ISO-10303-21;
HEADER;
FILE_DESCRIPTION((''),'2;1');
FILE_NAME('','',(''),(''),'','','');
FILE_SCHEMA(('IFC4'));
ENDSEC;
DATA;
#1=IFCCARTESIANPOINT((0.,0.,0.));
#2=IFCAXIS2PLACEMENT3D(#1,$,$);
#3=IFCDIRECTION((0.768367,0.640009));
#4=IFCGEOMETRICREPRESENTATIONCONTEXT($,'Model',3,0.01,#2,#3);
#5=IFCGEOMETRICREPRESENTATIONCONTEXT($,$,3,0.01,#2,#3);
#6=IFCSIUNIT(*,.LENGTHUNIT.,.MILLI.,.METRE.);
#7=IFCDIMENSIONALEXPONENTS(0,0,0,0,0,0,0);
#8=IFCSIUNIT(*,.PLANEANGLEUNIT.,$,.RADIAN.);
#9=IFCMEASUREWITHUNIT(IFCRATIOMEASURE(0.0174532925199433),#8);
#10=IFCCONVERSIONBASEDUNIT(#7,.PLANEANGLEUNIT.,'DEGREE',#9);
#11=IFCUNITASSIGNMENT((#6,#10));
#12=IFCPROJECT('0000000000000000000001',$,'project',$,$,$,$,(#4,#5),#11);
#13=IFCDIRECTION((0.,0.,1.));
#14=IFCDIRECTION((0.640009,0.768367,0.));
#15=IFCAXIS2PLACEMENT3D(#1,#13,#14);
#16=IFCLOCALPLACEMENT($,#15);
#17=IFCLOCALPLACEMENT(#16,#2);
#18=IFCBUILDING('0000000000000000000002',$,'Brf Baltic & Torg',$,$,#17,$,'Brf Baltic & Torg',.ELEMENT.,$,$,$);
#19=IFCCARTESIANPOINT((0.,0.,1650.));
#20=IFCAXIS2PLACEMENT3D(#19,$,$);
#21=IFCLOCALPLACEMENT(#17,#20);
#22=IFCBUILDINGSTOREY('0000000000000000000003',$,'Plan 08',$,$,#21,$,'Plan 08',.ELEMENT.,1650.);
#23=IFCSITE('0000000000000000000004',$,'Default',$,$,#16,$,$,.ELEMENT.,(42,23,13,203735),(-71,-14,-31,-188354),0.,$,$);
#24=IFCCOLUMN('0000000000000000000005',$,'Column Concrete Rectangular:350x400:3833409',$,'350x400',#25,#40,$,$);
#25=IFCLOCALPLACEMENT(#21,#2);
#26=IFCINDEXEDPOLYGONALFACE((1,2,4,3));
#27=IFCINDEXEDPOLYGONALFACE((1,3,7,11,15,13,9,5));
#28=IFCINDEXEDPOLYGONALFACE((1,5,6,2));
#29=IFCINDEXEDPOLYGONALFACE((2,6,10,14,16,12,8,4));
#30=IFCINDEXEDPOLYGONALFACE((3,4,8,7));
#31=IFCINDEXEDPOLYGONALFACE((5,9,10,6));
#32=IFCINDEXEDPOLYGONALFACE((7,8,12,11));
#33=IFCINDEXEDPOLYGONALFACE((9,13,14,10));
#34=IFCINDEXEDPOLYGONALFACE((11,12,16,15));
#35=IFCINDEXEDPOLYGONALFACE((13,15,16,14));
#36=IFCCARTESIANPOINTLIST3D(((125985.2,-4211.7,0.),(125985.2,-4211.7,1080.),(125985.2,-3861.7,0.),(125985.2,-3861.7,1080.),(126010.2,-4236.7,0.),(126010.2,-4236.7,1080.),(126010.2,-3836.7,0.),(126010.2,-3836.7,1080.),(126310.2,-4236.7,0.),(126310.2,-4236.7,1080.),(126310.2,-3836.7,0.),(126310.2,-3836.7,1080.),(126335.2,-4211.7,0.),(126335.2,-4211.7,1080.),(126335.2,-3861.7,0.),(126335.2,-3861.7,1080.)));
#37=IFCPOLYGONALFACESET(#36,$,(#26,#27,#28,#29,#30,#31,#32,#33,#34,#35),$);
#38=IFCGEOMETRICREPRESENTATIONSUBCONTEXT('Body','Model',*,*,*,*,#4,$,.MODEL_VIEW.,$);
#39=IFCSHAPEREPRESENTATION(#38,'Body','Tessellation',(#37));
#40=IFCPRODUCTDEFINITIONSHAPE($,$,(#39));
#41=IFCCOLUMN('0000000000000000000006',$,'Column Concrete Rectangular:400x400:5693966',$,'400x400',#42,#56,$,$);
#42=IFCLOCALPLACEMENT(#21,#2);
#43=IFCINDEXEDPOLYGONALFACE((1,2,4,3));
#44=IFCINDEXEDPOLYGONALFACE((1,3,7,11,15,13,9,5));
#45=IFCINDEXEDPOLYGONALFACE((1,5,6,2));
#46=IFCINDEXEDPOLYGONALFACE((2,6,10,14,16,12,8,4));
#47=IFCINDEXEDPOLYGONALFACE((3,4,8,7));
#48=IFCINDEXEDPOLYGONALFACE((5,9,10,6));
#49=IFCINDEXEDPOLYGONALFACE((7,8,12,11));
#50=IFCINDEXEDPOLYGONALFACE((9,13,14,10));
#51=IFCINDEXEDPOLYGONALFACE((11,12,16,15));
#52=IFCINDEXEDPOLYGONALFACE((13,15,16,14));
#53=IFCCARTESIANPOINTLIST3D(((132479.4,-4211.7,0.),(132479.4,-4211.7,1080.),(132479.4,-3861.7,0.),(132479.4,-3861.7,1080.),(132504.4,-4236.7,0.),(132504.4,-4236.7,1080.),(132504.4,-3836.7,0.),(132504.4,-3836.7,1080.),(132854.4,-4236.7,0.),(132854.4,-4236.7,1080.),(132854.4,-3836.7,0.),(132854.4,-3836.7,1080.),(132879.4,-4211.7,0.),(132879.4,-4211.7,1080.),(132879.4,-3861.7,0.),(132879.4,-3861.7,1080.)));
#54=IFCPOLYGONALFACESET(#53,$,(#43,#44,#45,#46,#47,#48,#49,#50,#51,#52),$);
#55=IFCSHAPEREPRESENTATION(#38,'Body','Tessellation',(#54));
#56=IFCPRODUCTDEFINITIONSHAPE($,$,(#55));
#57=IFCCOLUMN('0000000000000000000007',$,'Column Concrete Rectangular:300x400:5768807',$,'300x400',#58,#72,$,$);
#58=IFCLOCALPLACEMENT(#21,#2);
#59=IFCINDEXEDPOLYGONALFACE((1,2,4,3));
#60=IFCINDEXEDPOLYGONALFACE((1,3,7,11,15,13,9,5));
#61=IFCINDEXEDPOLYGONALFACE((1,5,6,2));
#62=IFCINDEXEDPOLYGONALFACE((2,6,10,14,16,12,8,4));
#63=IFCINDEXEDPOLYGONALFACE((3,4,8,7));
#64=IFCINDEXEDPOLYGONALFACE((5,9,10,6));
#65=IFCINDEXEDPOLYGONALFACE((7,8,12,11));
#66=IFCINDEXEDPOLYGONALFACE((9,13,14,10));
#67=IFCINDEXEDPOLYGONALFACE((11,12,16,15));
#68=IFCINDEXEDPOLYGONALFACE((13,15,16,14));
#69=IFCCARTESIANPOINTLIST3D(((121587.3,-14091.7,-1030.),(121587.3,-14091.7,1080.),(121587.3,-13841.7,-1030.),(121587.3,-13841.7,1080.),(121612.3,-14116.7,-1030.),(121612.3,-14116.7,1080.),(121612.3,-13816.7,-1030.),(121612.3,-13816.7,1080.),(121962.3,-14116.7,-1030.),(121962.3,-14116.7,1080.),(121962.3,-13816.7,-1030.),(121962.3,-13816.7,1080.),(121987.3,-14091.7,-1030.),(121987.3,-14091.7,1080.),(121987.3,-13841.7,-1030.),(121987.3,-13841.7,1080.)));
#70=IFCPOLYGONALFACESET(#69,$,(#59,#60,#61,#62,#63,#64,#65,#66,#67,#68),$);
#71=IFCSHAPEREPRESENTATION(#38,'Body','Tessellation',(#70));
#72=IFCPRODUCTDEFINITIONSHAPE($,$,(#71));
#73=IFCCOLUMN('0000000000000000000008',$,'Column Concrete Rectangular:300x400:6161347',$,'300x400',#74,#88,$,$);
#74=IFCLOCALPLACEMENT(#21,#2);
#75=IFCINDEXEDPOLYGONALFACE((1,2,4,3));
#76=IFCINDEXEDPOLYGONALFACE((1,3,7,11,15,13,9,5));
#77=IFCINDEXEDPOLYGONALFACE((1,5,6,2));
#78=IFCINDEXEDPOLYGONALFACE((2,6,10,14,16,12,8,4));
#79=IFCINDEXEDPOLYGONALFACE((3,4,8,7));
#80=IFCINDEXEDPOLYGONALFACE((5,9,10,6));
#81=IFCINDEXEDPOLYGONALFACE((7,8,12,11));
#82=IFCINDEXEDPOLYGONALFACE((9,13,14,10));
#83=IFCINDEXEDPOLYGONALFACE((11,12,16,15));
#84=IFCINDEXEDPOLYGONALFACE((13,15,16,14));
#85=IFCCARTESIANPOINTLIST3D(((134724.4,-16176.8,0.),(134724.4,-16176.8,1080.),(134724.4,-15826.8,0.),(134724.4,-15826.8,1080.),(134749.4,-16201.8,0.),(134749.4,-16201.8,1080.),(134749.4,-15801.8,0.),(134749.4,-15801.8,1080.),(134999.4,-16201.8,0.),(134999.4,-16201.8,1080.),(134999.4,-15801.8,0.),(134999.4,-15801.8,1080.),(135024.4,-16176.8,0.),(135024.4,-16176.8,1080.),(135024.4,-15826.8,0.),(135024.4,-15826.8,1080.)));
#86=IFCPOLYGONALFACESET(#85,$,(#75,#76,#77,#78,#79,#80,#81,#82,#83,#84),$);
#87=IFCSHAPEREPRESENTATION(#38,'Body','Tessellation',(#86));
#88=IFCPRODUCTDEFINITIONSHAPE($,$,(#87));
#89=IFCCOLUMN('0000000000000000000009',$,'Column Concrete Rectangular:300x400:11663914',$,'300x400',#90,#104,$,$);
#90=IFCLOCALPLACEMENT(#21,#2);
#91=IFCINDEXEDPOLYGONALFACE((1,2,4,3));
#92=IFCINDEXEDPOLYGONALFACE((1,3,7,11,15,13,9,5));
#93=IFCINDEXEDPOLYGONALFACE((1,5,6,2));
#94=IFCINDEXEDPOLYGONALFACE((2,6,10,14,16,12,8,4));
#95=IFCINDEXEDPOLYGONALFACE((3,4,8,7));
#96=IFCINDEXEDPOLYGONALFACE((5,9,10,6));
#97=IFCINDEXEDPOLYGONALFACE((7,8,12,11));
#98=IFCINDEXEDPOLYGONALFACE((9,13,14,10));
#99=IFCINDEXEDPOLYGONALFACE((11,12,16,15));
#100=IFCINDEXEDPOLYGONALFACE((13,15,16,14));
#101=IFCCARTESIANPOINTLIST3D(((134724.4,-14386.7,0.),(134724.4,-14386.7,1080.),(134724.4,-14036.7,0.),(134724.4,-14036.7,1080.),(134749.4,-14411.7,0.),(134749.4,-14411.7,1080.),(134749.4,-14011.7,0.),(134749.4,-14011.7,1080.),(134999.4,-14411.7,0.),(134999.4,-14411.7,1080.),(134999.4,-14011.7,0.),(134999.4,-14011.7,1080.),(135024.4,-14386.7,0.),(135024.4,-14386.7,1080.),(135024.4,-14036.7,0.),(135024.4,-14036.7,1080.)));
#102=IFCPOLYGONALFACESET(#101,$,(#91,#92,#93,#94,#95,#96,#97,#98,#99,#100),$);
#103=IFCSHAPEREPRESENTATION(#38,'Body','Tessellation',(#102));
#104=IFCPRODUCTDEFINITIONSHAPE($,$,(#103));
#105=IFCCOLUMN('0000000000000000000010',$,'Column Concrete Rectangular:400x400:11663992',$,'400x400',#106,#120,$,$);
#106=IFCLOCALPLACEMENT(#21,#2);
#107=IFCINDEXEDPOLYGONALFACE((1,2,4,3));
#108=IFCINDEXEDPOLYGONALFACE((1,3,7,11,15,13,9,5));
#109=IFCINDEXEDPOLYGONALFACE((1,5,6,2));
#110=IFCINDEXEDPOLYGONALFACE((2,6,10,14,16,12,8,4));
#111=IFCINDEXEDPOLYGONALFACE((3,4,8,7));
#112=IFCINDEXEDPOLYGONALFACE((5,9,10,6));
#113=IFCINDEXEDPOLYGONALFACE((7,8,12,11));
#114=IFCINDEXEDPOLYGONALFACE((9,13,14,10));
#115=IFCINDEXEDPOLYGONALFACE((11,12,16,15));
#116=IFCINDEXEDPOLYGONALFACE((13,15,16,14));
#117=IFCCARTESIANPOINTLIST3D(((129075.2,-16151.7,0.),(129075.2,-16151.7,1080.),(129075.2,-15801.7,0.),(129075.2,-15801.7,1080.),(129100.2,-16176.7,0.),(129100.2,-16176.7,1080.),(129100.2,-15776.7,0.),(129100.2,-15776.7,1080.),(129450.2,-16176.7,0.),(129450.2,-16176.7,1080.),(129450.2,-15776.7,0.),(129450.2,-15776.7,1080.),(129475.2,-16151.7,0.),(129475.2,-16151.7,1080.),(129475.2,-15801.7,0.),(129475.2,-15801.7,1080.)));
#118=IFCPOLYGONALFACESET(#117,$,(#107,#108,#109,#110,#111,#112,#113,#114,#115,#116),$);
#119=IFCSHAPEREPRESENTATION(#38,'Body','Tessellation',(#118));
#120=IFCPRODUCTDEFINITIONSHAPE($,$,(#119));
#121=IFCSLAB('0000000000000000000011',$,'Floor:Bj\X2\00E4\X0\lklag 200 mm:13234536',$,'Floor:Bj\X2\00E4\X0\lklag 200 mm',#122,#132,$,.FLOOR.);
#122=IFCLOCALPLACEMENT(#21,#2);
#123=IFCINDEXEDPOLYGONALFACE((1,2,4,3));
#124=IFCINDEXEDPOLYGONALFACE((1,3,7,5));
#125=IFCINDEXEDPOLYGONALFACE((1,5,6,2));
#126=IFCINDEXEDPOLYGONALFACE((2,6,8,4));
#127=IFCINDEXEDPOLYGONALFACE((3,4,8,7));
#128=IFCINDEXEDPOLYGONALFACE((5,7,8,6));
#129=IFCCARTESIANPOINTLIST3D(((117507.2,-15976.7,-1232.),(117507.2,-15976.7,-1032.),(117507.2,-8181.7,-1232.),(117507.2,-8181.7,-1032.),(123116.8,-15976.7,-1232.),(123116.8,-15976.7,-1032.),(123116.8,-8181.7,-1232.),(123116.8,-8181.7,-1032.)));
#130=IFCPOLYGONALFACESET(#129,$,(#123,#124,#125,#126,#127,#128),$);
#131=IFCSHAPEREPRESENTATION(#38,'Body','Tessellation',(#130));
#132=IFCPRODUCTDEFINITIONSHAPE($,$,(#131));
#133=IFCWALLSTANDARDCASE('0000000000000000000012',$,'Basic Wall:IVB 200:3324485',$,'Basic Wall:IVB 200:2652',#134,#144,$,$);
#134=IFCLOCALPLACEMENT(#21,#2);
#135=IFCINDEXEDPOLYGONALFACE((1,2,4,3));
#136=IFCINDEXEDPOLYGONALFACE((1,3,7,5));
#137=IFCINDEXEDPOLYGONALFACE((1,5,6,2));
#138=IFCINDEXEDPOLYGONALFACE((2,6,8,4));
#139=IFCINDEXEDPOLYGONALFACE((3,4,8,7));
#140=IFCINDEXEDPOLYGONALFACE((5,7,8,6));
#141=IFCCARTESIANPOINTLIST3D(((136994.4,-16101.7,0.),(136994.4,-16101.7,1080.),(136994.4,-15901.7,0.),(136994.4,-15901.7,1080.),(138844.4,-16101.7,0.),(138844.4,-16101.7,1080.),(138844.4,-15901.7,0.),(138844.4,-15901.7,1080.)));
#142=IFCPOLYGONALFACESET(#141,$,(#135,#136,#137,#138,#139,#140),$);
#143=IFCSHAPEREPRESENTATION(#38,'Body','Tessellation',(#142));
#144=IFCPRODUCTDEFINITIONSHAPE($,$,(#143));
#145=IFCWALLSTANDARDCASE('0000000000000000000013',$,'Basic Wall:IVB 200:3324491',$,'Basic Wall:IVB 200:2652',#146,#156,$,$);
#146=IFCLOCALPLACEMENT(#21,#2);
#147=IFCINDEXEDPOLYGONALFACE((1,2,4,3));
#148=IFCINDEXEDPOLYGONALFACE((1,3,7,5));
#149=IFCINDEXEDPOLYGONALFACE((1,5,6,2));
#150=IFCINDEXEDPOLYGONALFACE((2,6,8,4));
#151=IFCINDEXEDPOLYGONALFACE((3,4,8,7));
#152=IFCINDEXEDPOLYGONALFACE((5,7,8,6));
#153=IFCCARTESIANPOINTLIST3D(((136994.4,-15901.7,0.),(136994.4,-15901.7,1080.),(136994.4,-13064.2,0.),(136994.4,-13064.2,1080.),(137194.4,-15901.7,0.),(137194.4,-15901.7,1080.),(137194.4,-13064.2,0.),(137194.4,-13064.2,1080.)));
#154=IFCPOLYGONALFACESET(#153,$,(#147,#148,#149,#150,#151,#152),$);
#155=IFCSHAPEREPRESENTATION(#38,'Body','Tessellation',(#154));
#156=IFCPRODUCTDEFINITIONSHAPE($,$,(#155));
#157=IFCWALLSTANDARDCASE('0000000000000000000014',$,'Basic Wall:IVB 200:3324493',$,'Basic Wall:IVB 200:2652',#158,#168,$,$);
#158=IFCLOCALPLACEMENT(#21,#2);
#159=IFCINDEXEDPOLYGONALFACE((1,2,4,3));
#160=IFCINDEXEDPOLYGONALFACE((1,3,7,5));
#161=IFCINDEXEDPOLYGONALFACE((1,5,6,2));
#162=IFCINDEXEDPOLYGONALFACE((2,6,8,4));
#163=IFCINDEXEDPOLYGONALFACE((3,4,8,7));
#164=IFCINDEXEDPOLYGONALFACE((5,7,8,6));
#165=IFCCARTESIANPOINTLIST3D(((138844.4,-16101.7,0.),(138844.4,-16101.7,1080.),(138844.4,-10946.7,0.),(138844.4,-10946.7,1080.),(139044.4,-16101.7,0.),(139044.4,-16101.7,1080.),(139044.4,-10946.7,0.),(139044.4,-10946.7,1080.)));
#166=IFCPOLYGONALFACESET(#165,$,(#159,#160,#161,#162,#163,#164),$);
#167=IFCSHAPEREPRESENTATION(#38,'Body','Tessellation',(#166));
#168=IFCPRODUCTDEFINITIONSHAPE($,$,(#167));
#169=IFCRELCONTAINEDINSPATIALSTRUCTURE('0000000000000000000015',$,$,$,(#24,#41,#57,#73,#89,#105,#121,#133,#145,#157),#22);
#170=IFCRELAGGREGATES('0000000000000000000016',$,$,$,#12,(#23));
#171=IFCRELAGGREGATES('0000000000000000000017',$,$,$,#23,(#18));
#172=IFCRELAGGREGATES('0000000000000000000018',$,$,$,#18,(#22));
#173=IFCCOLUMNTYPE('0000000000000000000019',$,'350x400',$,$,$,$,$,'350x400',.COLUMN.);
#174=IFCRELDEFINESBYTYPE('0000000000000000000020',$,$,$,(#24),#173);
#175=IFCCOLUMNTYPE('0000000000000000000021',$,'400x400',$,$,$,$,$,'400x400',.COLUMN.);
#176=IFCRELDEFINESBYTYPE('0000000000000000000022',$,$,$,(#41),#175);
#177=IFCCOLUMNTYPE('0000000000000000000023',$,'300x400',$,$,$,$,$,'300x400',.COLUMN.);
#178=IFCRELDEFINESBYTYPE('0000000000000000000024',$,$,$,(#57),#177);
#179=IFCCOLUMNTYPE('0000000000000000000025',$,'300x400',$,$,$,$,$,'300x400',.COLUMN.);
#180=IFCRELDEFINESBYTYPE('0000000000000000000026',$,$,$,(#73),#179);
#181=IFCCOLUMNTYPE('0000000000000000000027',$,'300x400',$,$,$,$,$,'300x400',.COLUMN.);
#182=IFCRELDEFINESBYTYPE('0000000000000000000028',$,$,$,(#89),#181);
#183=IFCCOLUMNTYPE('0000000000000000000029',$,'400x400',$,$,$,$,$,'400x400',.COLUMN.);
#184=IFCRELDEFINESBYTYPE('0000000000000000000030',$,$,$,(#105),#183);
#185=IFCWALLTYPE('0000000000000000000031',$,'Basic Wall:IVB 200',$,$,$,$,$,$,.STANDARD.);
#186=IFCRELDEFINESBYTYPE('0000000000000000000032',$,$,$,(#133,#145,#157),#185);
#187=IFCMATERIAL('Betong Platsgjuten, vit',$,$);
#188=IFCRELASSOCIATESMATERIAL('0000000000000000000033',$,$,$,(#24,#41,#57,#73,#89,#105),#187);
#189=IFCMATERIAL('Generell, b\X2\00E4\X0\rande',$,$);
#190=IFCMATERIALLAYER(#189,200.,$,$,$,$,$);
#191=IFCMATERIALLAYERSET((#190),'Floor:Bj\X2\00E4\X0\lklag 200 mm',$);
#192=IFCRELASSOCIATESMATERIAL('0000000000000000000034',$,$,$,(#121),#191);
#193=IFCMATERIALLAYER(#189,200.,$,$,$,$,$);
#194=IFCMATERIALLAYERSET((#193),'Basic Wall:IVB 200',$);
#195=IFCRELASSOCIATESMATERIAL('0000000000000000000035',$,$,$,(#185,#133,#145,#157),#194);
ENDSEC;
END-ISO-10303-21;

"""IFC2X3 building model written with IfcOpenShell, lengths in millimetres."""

from ifc_helpers import new_model, entity, si_unit, converted_unit, direction, frame, frame_2d, origin, place, context, subcontext, project, spatial, polyline, rectangle, outline, extrude, clip, halfspace, source, transform, mapped, material, layer, layer_set, layer_usage, type_object, type_shapes, element, save


model = new_model("IFC2X3")

# Units and contexts
model_context = context("Model", 3, precision=0.01, world=origin(), true_north=direction((0.768367, 0.640009)))
context_of_model = context(None, 3, precision=0.01, world=origin(), true_north=direction((0.768367, 0.640009)))
body_context = subcontext(model_context, "Body", "Model", "MODEL_VIEW")
ifc_project = project(units=[si_unit("LENGTHUNIT", "METRE", prefix="MILLI"), converted_unit("PLANEANGLEUNIT", "DEGREE", entity("IfcRatioMeasure", 0.0174532925199433), si_unit("PLANEANGLEUNIT", "RADIAN"), dimensions=[0, 0, 0, 0, 0, 0, 0])], contexts=[model_context, context_of_model])

# Site, building, storey
site_placement = place(None, frame((0.0, 0.0, 0.0), z_axis=(0.0, 0.0, 1.0), x_axis=(0.640009, 0.768367, 0.0)))
site = spatial("IfcSite", under=ifc_project, at=site_placement, Name="Default", CompositionType="ELEMENT", RefLatitude=(42, 23, 13, 203735), RefLongitude=(-71, -14, -31, -188354), RefElevation=0.0)
building_placement = place(site_placement, origin())
building = spatial("IfcBuilding", under=site, at=building_placement, Name="Brf Baltic & Torg", LongName="Brf Baltic & Torg", CompositionType="ELEMENT")
storey_placement = place(building_placement, frame((0.0, 0.0, 1650.0)))
storey = spatial("IfcBuildingStorey", under=building, at=storey_placement, Name="Plan 08", LongName="Plan 08", CompositionType="ELEMENT", Elevation=1650.0)

# Columns
ifc_material_1 = material(Name="Betong Platsgjuten, vit")
column_type_1 = type_object("IfcColumnType", Name="350x400", ElementType="350x400", PredefinedType="COLUMN")
shared_shape_1 = source(origin(), body_context, "Body", "SweptSolid", [
    extrude(outline(polyline([(-175.0, -175.0), (175.0, -175.0), (200.0, -150.0), (200.0, 150.0), (175.0, 175.0), (-175.0, 175.0), (-200.0, 150.0), (-200.0, -150.0), (-175.0, -175.0)])), frame((0.0, 0.0, 1650.0), z_axis=(0.0, 0.0, 1.0), x_axis=(0.0, -1.0, 0.0)), (0.0, 0.0, 1.0), 1080.0),
])
type_shapes(column_type_1, [shared_shape_1])
column_1_placement = place(storey_placement, frame((126160.2, -4036.7, -1650.0)))
element("IfcColumn", 1, at=column_1_placement, inside=storey, type_object=column_type_1, material=ifc_material_1, Name="Column Concrete Rectangular:350x400:3833409", ObjectType="350x400", context=body_context, shape_type="MappedRepresentation", body=[
    mapped(shared_shape_1, transform((0.0, 0.0, 0.0), scale=1.0)),
])
column_type_2 = type_object("IfcColumnType", Name="400x400", ElementType="400x400", PredefinedType="COLUMN")
shared_shape_2 = source(origin(), body_context, "Body", "SweptSolid", [
    extrude(outline(polyline([(-175.0, -200.0), (175.0, -200.0), (200.0, -175.0), (200.0, 175.0), (175.0, 200.0), (-175.0, 200.0), (-200.0, 175.0), (-200.0, -175.0), (-175.0, -200.0)])), frame((0.0, 0.0, 1650.0), z_axis=(0.0, 0.0, 1.0), x_axis=(0.0, -1.0, 0.0)), (0.0, 0.0, 1.0), 1080.0),
])
type_shapes(column_type_2, [shared_shape_2])
column_2_placement = place(storey_placement, frame((132679.4, -4036.7, -1650.0)))
element("IfcColumn", 2, at=column_2_placement, inside=storey, type_object=column_type_2, material=ifc_material_1, Name="Column Concrete Rectangular:400x400:5693966", ObjectType="400x400", context=body_context, shape_type="MappedRepresentation", body=[
    mapped(shared_shape_2, transform((0.0, 0.0, 0.0), scale=1.0)),
])
column_type_3 = type_object("IfcColumnType", Name="300x400", ElementType="300x400", PredefinedType="COLUMN")
shared_shape_3 = source(origin(), body_context, "Body", "SweptSolid", [
    extrude(outline(polyline([(-175.0, -150.0), (175.0, -150.0), (200.0, -125.0), (200.0, 125.0), (175.0, 150.0), (-175.0, 150.0), (-200.0, 125.0), (-200.0, -125.0), (-175.0, -150.0)])), frame((0.0, 0.0, 620.0), z_axis=(0.0, 0.0, 1.0), x_axis=(0.0, -1.0, 0.0)), (0.0, 0.0, 1.0), 2110.0),
])
type_shapes(column_type_3, [shared_shape_3])
column_3_placement = place(storey_placement, frame((121787.3, -13966.7, -1650.0), z_axis=(0.0, 0.0, 1.0), x_axis=(0.0, 1.0, 0.0)))
element("IfcColumn", 3, at=column_3_placement, inside=storey, type_object=column_type_3, material=ifc_material_1, Name="Column Concrete Rectangular:300x400:5768807", ObjectType="300x400", context=body_context, shape_type="MappedRepresentation", body=[
    mapped(shared_shape_3, transform((0.0, 0.0, 0.0), scale=1.0)),
])
column_type_4 = type_object("IfcColumnType", Name="300x400", ElementType="300x400", PredefinedType="COLUMN")
shared_shape_4 = source(origin(), body_context, "Body", "SweptSolid", [
    extrude(outline(polyline([(-175.0, -150.0), (175.0, -150.0), (200.0, -125.0), (200.0, 125.0), (175.0, 150.0), (-175.0, 150.0), (-200.0, 125.0), (-200.0, -125.0), (-175.0, -150.0)])), frame((0.0, 0.0, 1650.0), z_axis=(0.0, 0.0, 1.0), x_axis=(0.0, -1.0, 0.0)), (0.0, 0.0, 1.0), 1080.0),
])
type_shapes(column_type_4, [shared_shape_4])
column_4_placement = place(storey_placement, frame((134874.4, -16001.8, -1650.0)))
element("IfcColumn", 4, at=column_4_placement, inside=storey, type_object=column_type_4, material=ifc_material_1, Name="Column Concrete Rectangular:300x400:6161347", ObjectType="300x400", context=body_context, shape_type="MappedRepresentation", body=[
    mapped(shared_shape_4, transform((0.0, 0.0, 0.0), scale=1.0)),
])
column_type_5 = type_object("IfcColumnType", Name="300x400", ElementType="300x400", PredefinedType="COLUMN")
shared_shape_5 = source(origin(), body_context, "Body", "SweptSolid", [
    extrude(outline(polyline([(-175.0, -150.0), (175.0, -150.0), (200.0, -125.0), (200.0, 125.0), (175.0, 150.0), (-175.0, 150.0), (-200.0, 125.0), (-200.0, -125.0), (-175.0, -150.0)])), frame((0.0, 0.0, 1650.0), z_axis=(0.0, 0.0, 1.0), x_axis=(0.0, -1.0, 0.0)), (0.0, 0.0, 1.0), 1080.0),
])
type_shapes(column_type_5, [shared_shape_5])
column_5_placement = place(storey_placement, frame((134874.4, -14211.7, -1650.0)))
element("IfcColumn", 5, at=column_5_placement, inside=storey, type_object=column_type_5, material=ifc_material_1, Name="Column Concrete Rectangular:300x400:11663914", ObjectType="300x400", context=body_context, shape_type="MappedRepresentation", body=[
    mapped(shared_shape_5, transform((0.0, 0.0, 0.0), scale=1.0)),
])
column_type_6 = type_object("IfcColumnType", Name="400x400", ElementType="400x400", PredefinedType="COLUMN")
shared_shape_6 = source(origin(), body_context, "Body", "SweptSolid", [
    extrude(outline(polyline([(-175.0, -200.0), (175.0, -200.0), (200.0, -175.0), (200.0, 175.0), (175.0, 200.0), (-175.0, 200.0), (-200.0, 175.0), (-200.0, -175.0), (-175.0, -200.0)])), frame((0.0, 0.0, 1650.0), z_axis=(0.0, 0.0, 1.0), x_axis=(0.0, -1.0, 0.0)), (0.0, 0.0, 1.0), 1080.0),
])
type_shapes(column_type_6, [shared_shape_6])
column_6_placement = place(storey_placement, frame((129275.2, -15976.7, -1650.0)))
element("IfcColumn", 6, at=column_6_placement, inside=storey, type_object=column_type_6, material=ifc_material_1, Name="Column Concrete Rectangular:400x400:11663992", ObjectType="400x400", context=body_context, shape_type="MappedRepresentation", body=[
    mapped(shared_shape_6, transform((0.0, 0.0, 0.0), scale=1.0)),
])

# Slab
ifc_material_2 = material(Name="Generell, bärande")
ifc_layer_1 = layer(ifc_material_2, 200.0)
ifc_layer_set_1 = layer_set([ifc_layer_1], Name="Floor:Bjälklag 200 mm")
ifc_layer_usage_1 = layer_usage(ifc_layer_set_1, "AXIS3", "POSITIVE", 0.0)
slab_1_placement = place(storey_placement, origin())
element("IfcSlab", 7, at=slab_1_placement, inside=storey, material=ifc_layer_usage_1, Name="Floor:Bjälklag 200 mm:13234536", ObjectType="Floor:Bjälklag 200 mm", PredefinedType="FLOOR", context=body_context, shape_type="SweptSolid", body=[
    extrude(rectangle(XDim=7795.0, YDim=5609.6, at=frame_2d((0.0, 0.0), x_axis=(1.0, 0.0))), frame((120312.0, -12079.2, -1032.0), z_axis=(0.0, 0.0, -1.0), x_axis=(0.0, 1.0, 0.0)), (0.0, 0.0, 1.0), 200.0),
])

# Wall
ifc_layer_2 = layer(ifc_material_2, 200.0)
ifc_layer_set_2 = layer_set([ifc_layer_2], Name="Basic Wall:IVB 200")
ifc_layer_usage_2 = layer_usage(ifc_layer_set_2, "AXIS2", "NEGATIVE", 100.0)
wall_type = type_object("IfcWallType", Name="Basic Wall:IVB 200", PredefinedType="STANDARD", material=ifc_layer_set_2)
wall_1_placement = place(storey_placement, frame((138844.4, -16001.7, 0.0), z_axis=(0.0, 0.0, 1.0), x_axis=(-1.0, 0.0, 0.0)))
element("IfcWallStandardCase", 8, at=wall_1_placement, inside=storey, type_object=wall_type, material=ifc_layer_usage_2, Name="Basic Wall:IVB 200:3324485", ObjectType="Basic Wall:IVB 200:2652", context=body_context, shape_type="Clipping", body=[
    clip(extrude(rectangle(XDim=1850.0, YDim=200.0, at=frame_2d((925.0, 0.0), x_axis=(-1.0, 0.0))), origin(), (0.0, 0.0, 1.0), 1080.0), halfspace(origin(), True)),
])

# Walls
ifc_layer_usage_3 = layer_usage(ifc_layer_set_2, "AXIS2", "NEGATIVE", 100.0)
wall_2_placement = place(storey_placement, frame((137094.4, -15901.7, 0.0), z_axis=(0.0, 0.0, 1.0), x_axis=(0.0, 1.0, 0.0)))
element("IfcWallStandardCase", 9, at=wall_2_placement, inside=storey, type_object=wall_type, material=ifc_layer_usage_3, Name="Basic Wall:IVB 200:3324491", ObjectType="Basic Wall:IVB 200:2652", context=body_context, shape_type="Clipping", body=[
    clip(extrude(rectangle(XDim=2837.5, YDim=200.0, at=frame_2d((1418.8, 0.0), x_axis=(-1.0, 0.0))), origin(), (0.0, 0.0, 1.0), 1080.0), halfspace(origin(), True)),
])
ifc_layer_usage_4 = layer_usage(ifc_layer_set_2, "AXIS2", "NEGATIVE", 100.0)
wall_3_placement = place(storey_placement, frame((138944.4, -10946.7, 0.0), z_axis=(0.0, 0.0, 1.0), x_axis=(0.0, -1.0, 0.0)))
element("IfcWallStandardCase", 10, at=wall_3_placement, inside=storey, type_object=wall_type, material=ifc_layer_usage_4, Name="Basic Wall:IVB 200:3324493", ObjectType="Basic Wall:IVB 200:2652", context=body_context, shape_type="Clipping", body=[
    clip(extrude(rectangle(XDim=5155.0, YDim=200.0, at=frame_2d((2577.5, 0.0), x_axis=(-1.0, 0.0))), origin(), (0.0, 0.0, 1.0), 1080.0), halfspace(origin(), True)),
])

save(model, "model.ifc")
